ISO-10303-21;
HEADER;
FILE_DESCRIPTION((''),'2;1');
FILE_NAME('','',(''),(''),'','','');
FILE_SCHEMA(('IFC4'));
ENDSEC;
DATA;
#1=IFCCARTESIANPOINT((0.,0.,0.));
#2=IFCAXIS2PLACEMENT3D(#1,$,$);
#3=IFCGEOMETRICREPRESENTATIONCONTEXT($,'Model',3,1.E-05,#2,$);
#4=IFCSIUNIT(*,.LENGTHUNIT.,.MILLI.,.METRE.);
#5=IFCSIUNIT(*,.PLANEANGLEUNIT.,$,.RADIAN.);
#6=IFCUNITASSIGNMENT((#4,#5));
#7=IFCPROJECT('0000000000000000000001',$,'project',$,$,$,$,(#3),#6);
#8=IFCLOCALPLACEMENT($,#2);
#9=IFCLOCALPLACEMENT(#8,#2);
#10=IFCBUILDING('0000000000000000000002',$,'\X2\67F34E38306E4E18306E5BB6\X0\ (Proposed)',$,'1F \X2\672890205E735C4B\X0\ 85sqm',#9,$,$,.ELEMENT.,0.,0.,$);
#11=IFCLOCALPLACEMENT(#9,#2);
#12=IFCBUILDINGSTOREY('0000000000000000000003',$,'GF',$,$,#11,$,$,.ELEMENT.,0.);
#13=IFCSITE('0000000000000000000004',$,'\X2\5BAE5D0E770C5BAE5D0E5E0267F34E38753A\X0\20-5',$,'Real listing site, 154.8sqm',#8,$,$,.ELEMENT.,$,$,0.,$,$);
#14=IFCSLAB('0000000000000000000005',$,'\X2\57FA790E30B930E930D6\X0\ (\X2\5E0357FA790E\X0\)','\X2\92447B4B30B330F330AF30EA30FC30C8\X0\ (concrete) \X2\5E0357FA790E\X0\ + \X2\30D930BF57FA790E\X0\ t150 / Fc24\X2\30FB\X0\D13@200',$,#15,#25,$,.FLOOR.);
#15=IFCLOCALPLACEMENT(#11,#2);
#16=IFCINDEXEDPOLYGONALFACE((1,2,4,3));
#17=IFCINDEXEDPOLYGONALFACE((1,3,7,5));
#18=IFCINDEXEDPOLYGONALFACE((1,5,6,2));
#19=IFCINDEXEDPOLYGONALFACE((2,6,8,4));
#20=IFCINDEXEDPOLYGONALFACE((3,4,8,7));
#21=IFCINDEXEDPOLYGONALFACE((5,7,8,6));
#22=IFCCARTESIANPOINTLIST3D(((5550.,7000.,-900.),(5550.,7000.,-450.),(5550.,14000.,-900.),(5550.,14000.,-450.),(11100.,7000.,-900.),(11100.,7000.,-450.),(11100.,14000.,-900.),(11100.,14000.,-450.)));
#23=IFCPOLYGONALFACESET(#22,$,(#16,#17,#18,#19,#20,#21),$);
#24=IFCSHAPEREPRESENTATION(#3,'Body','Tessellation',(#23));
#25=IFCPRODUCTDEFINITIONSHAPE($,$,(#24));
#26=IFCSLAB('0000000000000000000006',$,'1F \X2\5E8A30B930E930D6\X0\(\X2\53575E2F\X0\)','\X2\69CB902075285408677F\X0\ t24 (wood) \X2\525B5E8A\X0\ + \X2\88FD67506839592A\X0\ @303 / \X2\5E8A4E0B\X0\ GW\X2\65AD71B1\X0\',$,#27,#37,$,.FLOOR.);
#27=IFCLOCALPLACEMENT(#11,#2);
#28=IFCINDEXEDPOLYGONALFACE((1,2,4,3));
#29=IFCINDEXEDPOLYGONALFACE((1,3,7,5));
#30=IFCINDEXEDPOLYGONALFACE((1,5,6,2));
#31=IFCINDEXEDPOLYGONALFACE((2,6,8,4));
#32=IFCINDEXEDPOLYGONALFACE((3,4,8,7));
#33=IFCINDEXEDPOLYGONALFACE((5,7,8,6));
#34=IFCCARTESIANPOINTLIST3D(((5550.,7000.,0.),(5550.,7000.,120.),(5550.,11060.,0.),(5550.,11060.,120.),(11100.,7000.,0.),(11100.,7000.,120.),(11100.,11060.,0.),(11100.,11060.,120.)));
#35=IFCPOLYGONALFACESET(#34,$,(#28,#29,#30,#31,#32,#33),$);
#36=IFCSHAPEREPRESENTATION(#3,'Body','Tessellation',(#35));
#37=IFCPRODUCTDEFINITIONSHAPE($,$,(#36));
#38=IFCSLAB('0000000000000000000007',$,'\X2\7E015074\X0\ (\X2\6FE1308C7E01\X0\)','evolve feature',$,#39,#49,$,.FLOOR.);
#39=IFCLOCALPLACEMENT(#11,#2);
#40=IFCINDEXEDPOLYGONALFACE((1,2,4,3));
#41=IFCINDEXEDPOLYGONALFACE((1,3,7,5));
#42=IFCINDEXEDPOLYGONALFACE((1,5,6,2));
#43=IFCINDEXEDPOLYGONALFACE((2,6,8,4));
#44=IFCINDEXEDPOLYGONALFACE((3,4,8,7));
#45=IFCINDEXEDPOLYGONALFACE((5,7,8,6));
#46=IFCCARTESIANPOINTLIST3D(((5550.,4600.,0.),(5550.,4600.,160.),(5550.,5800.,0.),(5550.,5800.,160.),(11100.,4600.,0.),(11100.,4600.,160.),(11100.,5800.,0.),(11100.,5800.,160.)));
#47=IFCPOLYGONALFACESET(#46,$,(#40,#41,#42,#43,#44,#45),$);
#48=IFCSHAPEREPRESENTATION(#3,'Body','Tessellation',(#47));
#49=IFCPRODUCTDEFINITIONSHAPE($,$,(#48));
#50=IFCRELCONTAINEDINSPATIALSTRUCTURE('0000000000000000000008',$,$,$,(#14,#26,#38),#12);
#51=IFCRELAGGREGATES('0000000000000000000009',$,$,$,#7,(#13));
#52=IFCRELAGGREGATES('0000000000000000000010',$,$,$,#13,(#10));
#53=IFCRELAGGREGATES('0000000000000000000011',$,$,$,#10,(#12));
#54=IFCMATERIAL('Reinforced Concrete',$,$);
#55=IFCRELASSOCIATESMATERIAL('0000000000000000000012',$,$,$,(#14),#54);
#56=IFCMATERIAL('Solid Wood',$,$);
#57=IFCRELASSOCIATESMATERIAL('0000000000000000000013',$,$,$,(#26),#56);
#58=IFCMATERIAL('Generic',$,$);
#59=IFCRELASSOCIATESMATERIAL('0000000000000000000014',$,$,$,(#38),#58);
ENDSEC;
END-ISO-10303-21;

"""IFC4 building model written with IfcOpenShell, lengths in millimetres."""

from ifc_helpers import new_model, si_unit, frame, frame_2d, origin, place, context, project, spatial, rectangle, extrude, material, element, save


model = new_model("IFC4")

# Units and contexts
model_context = context("Model", 3, precision=1e-05, world=origin())
ifc_project = project(units=[si_unit("LENGTHUNIT", "METRE", prefix="MILLI"), si_unit("PLANEANGLEUNIT", "RADIAN")], contexts=[model_context])

# Site, building, storey
site_placement = place(None, origin())
site = spatial("IfcSite", under=ifc_project, at=site_placement, Name="宮崎県宮崎市柳丸町20-5", ObjectType="Real listing site, 154.8sqm", CompositionType="ELEMENT", RefElevation=0.0)
building_placement = place(site_placement, origin())
building = spatial("IfcBuilding", under=site, at=building_placement, Name="柳丸の丘の家 (Proposed)", ObjectType="1F 木造平屋 85sqm", CompositionType="ELEMENT", ElevationOfRefHeight=0.0, ElevationOfTerrain=0.0)
storey_placement = place(building_placement, origin())
storey = spatial("IfcBuildingStorey", under=building, at=storey_placement, Name="GF", CompositionType="ELEMENT", Elevation=0.0)

# Slabs
ifc_material_1 = material(Name="Reinforced Concrete")
slab_1_placement = place(storey_placement, frame((2775.0, 3500.0, -450.0)))
element("IfcSlab", 1, at=slab_1_placement, inside=storey, material=ifc_material_1, Name="基礎スラブ (布基礎)", Description="鉄筋コンクリート (concrete) 布基礎 + ベタ基礎 t150 / Fc24・D13@200", PredefinedType="FLOOR", context=model_context, shape_type="SweptSolid", body=[
    extrude(rectangle(XDim=5550.0, YDim=7000.0, at=frame_2d((2775.0, 3500.0))), frame((2775.0, 3500.0, -450.0)), (0.0, 0.0, 1.0), 450.0),
])
ifc_material_2 = material(Name="Solid Wood")
slab_2_placement = place(storey_placement, frame((2775.0, 3500.0, 0.0)))
element("IfcSlab", 2, at=slab_2_placement, inside=storey, material=ifc_material_2, Name="1F 床スラブ(南帯)", Description="構造用合板 t24 (wood) 剛床 + 製材根太 @303 / 床下 GW断熱", PredefinedType="FLOOR", context=model_context, shape_type="SweptSolid", body=[
    extrude(rectangle(XDim=5550.0, YDim=4060.0, at=frame_2d((2775.0, 2030.0))), frame((2775.0, 3500.0, 0.0)), (0.0, 0.0, 1.0), 120.0),
])
ifc_material_3 = material(Name="Generic")
slab_3_placement = place(storey_placement, frame((2775.0, 2300.0, 0.0)))
element("IfcSlab", 3, at=slab_3_placement, inside=storey, material=ifc_material_3, Name="縁側 (濡れ縁)", Description="evolve feature", PredefinedType="FLOOR", context=model_context, shape_type="SweptSolid", body=[
    extrude(rectangle(XDim=5550.0, YDim=1200.0, at=frame_2d((2775.0, 600.0))), frame((2775.0, 2300.0, 0.0)), (0.0, 0.0, 1.0), 160.0),
])

save(model, "model.ifc")
